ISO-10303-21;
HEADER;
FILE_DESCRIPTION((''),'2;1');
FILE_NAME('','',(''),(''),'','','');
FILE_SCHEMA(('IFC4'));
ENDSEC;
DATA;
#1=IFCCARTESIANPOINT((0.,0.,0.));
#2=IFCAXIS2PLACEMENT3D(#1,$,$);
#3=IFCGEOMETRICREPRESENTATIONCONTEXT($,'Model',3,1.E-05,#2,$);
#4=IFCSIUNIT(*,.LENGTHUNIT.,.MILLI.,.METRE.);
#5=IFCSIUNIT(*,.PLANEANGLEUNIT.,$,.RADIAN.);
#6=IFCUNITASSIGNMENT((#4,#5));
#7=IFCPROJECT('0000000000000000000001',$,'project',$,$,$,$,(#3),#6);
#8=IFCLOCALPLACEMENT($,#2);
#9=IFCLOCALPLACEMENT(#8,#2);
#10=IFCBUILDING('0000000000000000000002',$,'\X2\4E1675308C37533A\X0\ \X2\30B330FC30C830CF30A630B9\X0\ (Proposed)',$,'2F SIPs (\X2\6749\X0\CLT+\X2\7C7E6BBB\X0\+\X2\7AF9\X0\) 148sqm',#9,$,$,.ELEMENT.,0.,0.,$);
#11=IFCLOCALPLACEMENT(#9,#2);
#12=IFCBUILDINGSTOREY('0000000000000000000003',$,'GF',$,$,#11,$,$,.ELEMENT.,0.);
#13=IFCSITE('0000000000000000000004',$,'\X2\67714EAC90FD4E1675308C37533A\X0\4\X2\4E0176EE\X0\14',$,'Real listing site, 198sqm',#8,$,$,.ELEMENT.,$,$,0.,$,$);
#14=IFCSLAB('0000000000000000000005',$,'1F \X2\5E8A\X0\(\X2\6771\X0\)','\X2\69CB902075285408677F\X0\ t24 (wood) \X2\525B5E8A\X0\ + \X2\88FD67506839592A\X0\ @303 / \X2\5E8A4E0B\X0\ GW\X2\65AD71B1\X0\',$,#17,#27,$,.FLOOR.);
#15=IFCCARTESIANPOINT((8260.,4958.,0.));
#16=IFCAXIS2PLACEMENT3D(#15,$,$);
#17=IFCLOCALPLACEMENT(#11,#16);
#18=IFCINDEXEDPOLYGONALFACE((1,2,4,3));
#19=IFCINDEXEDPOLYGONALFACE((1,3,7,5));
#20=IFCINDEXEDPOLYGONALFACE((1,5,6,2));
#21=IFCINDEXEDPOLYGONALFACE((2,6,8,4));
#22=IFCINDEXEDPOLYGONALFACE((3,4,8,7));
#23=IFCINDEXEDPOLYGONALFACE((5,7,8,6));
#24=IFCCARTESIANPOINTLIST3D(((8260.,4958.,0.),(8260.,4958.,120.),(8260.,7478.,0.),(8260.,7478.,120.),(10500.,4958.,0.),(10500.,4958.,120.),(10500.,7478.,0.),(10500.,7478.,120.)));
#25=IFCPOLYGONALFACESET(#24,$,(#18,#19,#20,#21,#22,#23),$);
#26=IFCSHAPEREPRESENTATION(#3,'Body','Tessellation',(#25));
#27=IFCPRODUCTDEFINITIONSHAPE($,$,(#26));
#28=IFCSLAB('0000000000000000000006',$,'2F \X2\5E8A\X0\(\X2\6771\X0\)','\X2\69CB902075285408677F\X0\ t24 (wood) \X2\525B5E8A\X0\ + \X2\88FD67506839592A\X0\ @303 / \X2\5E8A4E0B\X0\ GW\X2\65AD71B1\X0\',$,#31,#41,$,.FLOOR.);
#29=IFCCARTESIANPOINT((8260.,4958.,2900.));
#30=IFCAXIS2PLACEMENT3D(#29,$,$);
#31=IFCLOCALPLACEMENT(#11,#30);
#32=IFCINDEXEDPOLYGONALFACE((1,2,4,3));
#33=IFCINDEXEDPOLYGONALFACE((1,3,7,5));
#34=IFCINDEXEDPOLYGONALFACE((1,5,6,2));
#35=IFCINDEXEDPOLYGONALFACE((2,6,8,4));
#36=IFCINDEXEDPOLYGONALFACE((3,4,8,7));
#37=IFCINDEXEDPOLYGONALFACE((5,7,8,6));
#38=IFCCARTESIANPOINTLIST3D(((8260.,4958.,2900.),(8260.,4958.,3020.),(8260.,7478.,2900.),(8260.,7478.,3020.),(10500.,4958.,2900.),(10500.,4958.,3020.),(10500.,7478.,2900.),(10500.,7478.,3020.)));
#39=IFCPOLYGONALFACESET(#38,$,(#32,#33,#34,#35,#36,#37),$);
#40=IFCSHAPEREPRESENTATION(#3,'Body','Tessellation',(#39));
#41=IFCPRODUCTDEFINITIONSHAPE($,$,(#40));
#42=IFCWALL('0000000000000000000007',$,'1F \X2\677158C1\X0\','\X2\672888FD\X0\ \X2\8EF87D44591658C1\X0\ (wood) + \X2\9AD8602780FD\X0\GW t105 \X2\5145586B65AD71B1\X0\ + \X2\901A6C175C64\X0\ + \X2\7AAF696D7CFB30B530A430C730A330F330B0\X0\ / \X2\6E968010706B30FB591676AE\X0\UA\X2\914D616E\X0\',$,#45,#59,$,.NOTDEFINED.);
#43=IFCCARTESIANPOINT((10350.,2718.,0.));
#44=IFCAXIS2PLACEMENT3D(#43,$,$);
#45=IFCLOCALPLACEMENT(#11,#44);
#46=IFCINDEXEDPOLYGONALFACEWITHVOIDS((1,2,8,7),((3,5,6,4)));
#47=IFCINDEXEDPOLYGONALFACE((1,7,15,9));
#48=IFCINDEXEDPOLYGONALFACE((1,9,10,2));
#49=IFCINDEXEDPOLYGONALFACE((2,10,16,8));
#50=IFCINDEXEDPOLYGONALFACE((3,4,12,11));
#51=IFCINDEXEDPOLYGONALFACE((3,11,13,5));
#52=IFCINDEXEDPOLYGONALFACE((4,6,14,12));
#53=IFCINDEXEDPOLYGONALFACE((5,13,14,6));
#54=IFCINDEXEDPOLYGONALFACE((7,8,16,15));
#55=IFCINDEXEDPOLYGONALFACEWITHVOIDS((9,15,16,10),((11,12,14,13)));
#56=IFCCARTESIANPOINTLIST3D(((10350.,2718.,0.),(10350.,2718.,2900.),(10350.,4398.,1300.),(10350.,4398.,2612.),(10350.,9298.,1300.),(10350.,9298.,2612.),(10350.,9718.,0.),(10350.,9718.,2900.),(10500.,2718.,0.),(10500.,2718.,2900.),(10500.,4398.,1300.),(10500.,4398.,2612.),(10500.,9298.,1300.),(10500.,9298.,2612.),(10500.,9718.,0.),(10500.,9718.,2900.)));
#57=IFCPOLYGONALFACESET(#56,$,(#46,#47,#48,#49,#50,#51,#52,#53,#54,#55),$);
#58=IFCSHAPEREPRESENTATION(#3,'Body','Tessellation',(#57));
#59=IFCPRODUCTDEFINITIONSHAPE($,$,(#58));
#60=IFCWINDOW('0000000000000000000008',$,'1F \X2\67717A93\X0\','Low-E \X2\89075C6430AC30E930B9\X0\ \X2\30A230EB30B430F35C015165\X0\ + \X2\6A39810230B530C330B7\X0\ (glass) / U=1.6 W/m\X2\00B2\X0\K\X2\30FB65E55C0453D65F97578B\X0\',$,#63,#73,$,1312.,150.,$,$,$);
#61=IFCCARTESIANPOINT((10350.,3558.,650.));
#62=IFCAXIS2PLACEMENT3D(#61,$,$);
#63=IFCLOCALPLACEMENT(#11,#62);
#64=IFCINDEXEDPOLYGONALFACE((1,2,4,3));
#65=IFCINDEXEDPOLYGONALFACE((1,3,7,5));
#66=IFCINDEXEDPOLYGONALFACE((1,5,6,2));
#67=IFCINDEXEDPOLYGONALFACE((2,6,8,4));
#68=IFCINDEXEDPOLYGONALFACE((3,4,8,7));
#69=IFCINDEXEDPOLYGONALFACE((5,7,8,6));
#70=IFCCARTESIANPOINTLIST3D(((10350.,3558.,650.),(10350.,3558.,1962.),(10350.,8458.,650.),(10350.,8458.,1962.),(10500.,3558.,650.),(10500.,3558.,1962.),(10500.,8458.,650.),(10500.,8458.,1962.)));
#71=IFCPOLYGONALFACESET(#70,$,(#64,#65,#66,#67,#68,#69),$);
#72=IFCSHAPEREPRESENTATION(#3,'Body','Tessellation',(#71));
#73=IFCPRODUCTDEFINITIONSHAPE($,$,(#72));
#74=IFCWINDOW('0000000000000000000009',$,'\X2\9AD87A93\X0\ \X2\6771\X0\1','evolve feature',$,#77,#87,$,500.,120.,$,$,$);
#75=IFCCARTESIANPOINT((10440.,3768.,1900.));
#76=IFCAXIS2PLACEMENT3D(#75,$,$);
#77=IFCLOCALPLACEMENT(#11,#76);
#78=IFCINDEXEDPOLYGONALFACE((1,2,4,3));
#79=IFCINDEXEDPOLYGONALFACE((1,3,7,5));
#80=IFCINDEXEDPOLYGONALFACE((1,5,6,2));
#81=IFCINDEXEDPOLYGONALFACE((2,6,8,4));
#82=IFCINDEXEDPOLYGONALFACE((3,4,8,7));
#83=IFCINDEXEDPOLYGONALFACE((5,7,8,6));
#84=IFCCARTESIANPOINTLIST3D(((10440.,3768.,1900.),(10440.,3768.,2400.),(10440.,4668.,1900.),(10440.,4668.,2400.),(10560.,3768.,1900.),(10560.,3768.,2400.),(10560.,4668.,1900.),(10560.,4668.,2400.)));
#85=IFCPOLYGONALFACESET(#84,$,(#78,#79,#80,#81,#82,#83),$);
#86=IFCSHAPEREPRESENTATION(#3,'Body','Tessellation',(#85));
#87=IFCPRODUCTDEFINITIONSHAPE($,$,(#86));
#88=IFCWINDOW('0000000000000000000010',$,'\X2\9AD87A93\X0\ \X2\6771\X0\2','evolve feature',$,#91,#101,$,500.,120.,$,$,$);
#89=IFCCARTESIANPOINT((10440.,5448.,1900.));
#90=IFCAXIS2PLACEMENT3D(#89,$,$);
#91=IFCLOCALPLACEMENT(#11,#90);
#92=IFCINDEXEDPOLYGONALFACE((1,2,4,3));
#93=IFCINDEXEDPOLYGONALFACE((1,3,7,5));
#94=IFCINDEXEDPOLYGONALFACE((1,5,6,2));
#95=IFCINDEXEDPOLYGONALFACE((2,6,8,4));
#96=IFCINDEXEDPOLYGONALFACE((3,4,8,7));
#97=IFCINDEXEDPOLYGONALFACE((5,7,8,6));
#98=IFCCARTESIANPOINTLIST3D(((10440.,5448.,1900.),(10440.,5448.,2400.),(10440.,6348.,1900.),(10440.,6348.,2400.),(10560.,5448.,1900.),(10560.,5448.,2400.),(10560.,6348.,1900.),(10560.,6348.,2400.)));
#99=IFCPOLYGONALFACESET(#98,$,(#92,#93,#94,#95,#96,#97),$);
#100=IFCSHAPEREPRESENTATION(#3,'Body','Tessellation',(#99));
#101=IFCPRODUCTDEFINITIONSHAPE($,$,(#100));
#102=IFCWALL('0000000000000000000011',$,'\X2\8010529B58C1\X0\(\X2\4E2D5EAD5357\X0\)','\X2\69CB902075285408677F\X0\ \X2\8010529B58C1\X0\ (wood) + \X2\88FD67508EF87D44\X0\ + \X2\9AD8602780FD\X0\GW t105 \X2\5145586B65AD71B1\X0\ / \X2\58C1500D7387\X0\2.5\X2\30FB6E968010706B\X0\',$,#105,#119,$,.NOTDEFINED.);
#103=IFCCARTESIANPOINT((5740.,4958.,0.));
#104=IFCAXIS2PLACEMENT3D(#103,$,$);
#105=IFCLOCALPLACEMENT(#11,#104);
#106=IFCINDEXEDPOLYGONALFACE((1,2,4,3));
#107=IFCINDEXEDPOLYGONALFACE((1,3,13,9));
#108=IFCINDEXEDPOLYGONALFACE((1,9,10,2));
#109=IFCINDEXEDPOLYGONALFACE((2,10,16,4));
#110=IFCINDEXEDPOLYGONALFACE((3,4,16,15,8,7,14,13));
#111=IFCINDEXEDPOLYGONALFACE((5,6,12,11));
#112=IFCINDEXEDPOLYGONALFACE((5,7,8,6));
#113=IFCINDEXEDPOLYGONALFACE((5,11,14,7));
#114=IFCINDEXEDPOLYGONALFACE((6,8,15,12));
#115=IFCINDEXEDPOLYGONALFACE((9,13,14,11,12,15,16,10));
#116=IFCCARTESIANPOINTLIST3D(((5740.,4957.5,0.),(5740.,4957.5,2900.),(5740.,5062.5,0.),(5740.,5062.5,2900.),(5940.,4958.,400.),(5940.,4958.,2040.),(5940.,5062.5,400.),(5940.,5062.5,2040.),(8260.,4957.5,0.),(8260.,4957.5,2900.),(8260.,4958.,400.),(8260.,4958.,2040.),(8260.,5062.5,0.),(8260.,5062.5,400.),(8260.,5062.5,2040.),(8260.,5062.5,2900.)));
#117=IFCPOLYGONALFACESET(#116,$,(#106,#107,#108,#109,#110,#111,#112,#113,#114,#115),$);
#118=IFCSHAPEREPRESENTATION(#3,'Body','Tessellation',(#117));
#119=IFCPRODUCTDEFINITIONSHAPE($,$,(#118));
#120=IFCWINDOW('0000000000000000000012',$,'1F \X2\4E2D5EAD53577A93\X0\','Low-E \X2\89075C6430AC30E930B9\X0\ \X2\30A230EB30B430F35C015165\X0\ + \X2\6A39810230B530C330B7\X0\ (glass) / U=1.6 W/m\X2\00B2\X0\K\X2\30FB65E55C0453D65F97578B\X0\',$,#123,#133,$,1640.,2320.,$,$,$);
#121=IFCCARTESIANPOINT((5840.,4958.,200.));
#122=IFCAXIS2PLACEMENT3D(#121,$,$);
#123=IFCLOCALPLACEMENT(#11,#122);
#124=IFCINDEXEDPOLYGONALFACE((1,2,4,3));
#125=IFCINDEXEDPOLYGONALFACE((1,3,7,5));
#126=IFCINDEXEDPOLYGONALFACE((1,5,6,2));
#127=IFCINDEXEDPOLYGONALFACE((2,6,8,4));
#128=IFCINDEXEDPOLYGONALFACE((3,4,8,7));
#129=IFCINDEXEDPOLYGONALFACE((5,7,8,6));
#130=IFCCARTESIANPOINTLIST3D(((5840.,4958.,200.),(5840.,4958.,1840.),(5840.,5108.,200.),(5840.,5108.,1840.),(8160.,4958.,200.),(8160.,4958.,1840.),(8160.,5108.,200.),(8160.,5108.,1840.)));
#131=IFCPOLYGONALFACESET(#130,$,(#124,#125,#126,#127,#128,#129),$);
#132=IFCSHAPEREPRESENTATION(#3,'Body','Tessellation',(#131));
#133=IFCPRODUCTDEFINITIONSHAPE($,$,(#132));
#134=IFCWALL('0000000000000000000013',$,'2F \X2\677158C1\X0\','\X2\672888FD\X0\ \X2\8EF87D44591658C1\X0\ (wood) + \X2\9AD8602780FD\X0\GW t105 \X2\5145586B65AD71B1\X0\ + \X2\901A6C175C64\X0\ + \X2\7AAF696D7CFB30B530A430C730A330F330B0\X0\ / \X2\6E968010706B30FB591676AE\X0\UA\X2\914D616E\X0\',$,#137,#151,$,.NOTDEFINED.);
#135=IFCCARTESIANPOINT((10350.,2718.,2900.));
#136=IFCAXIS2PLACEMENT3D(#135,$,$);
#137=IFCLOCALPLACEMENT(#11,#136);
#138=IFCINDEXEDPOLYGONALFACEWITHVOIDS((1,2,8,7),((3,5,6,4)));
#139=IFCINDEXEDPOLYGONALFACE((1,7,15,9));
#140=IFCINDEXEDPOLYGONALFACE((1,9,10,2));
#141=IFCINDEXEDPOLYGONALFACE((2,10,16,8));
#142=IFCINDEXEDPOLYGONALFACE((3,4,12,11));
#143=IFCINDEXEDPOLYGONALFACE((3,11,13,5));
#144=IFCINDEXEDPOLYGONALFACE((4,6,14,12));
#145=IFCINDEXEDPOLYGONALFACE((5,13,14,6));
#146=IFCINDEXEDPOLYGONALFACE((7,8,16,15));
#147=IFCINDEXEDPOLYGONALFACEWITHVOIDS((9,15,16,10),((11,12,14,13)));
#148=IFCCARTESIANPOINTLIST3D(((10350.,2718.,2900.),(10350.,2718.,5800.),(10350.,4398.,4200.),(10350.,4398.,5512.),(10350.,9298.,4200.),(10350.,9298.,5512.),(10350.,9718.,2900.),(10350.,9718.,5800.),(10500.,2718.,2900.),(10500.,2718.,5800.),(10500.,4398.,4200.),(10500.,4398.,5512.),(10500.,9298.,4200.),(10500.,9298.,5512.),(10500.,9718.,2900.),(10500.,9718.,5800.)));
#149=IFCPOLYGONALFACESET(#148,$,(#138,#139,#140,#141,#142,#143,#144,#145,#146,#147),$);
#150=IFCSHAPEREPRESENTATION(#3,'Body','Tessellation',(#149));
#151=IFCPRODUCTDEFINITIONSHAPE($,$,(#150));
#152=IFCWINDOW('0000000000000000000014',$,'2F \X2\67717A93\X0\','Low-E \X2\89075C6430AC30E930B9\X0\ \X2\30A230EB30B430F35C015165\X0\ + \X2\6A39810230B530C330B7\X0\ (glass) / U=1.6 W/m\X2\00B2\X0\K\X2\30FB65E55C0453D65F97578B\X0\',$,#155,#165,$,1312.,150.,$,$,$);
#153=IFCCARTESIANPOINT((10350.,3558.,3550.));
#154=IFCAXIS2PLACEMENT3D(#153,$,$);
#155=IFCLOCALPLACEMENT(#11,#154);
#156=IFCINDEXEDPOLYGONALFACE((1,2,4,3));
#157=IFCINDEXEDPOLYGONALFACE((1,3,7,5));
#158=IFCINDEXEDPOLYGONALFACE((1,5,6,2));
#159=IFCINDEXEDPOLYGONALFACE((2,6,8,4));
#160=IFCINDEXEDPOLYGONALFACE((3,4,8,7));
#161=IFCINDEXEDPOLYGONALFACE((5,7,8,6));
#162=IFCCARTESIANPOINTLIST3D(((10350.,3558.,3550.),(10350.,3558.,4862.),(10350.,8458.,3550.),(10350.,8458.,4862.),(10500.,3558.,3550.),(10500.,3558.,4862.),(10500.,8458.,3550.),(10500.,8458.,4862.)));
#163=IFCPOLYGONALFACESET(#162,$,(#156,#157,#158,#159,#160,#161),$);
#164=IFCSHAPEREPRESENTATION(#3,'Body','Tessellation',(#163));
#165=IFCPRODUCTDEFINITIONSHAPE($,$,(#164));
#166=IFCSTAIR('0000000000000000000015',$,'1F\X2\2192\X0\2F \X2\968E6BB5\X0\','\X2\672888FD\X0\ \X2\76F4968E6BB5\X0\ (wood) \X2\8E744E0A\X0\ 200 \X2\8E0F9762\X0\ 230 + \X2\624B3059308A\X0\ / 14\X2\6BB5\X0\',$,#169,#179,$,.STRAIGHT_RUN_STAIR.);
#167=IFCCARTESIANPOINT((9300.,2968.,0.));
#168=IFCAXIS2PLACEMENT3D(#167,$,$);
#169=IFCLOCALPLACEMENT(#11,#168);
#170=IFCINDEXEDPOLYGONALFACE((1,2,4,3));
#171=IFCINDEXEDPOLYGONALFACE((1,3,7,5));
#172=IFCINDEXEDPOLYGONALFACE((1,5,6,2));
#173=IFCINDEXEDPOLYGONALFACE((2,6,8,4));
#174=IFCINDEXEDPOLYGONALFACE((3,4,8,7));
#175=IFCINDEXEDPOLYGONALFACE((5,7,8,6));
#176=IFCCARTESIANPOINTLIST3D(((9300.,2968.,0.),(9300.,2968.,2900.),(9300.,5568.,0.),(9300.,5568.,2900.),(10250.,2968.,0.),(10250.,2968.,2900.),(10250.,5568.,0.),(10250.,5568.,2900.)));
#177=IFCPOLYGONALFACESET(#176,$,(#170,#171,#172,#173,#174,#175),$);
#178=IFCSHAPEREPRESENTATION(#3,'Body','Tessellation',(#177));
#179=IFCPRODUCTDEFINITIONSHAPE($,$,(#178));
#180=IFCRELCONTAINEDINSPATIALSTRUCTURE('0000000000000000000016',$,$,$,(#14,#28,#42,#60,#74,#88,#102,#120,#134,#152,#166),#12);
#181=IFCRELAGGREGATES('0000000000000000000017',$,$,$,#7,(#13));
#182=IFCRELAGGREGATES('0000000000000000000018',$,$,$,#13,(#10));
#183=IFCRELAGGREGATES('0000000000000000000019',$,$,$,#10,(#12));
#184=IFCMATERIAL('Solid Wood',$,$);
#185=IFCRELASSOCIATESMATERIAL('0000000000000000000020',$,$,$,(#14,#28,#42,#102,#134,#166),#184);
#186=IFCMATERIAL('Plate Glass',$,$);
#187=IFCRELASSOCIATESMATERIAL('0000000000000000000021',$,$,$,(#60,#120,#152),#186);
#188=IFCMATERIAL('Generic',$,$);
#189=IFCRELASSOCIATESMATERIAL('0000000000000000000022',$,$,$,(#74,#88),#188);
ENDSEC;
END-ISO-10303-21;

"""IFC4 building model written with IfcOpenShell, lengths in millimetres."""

from ifc_helpers import new_model, si_unit, frame, frame_2d, origin, place, context, project, spatial, rectangle, extrude, material, element, fill, save


model = new_model("IFC4")

# Units and contexts
model_context = context("Model", 3, precision=1e-05, world=origin())
ifc_project = project(units=[si_unit("LENGTHUNIT", "METRE", prefix="MILLI"), si_unit("PLANEANGLEUNIT", "RADIAN")], contexts=[model_context])

# Site, building, storey
site_placement = place(None, origin())
site = spatial("IfcSite", under=ifc_project, at=site_placement, Name="東京都世田谷区4丁目14", ObjectType="Real listing site, 198sqm", CompositionType="ELEMENT", RefElevation=0.0)
building_placement = place(site_placement, origin())
building = spatial("IfcBuilding", under=site, at=building_placement, Name="世田谷区 コートハウス (Proposed)", ObjectType="2F SIPs (杉CLT+籾殻+竹) 148sqm", CompositionType="ELEMENT", ElevationOfRefHeight=0.0, ElevationOfTerrain=0.0)
storey_placement = place(building_placement, origin())
storey = spatial("IfcBuildingStorey", under=building, at=storey_placement, Name="GF", CompositionType="ELEMENT", Elevation=0.0)

# Slabs
ifc_material_1 = material(Name="Solid Wood")
slab_1_placement = place(storey_placement, frame((8260.0, 4958.0, 0.0)))
element("IfcSlab", 1, at=slab_1_placement, inside=storey, material=ifc_material_1, Name="1F 床(東)", Description="構造用合板 t24 (wood) 剛床 + 製材根太 @303 / 床下 GW断熱", PredefinedType="FLOOR", context=model_context, shape_type="SweptSolid", body=[
    extrude(rectangle(XDim=2240.0, YDim=2520.0, at=frame_2d((1120.0, 1260.0))), frame((8260.0, 4958.0, 0.0)), (0.0, 0.0, 1.0), 120.0),
])
slab_2_placement = place(storey_placement, frame((8260.0, 4958.0, 2900.0)))
element("IfcSlab", 2, at=slab_2_placement, inside=storey, material=ifc_material_1, Name="2F 床(東)", Description="構造用合板 t24 (wood) 剛床 + 製材根太 @303 / 床下 GW断熱", PredefinedType="FLOOR", context=model_context, shape_type="SweptSolid", body=[
    extrude(rectangle(XDim=2240.0, YDim=2520.0, at=frame_2d((1120.0, 1260.0))), frame((8260.0, 4958.0, 2900.0)), (0.0, 0.0, 1.0), 120.0),
])

# Wall, openings, windows
wall_1_placement = place(storey_placement, frame((10350.0, 2718.0, 0.0)))
wall_1 = element("IfcWall", 3, at=wall_1_placement, inside=storey, material=ifc_material_1, Name="1F 東壁", Description="木製 軸組外壁 (wood) + 高性能GW t105 充填断熱 + 通気層 + 窯業系サイディング / 準耐火・外皮UA配慮", PredefinedType="NOTDEFINED", context=model_context, shape_type="SweptSolid", body=[
    extrude(rectangle(XDim=150.0, YDim=7000.0, at=frame_2d((75.0, 3500.0))), frame((10350.0, 2718.0, 0.0)), (0.0, 0.0, 1.0), 2900.0),
])
opening_1_placement = place(storey_placement, frame((10350.0, 3558.0, 650.0)))
opening_1 = element("IfcOpeningElement", 4, at=opening_1_placement, cuts=wall_1, PredefinedType="NOTDEFINED", context=model_context, shape_type="SweptSolid", body=[
    extrude(rectangle(XDim=150.0, YDim=4900.0, at=frame_2d((75.0, 2450.0))), frame((10350.0, 3558.0, 650.0)), (0.0, 0.0, 1.0), 1312.0),
])
opening_2_placement = place(storey_placement, frame((10440.0, 3768.0, 1900.0)))
opening_2 = element("IfcOpeningElement", 5, at=opening_2_placement, cuts=wall_1, PredefinedType="NOTDEFINED", context=model_context, shape_type="SweptSolid", body=[
    extrude(rectangle(XDim=120.0, YDim=900.0, at=frame_2d((60.0, 450.0))), frame((10440.0, 3768.0, 1900.0)), (0.0, 0.0, 1.0), 500.0),
])
opening_3_placement = place(storey_placement, frame((10440.0, 5448.0, 1900.0)))
opening_3 = element("IfcOpeningElement", 6, at=opening_3_placement, cuts=wall_1, PredefinedType="NOTDEFINED", context=model_context, shape_type="SweptSolid", body=[
    extrude(rectangle(XDim=120.0, YDim=900.0, at=frame_2d((60.0, 450.0))), frame((10440.0, 5448.0, 1900.0)), (0.0, 0.0, 1.0), 500.0),
])
ifc_material_2 = material(Name="Plate Glass")
window_1_placement = place(storey_placement, frame((10350.0, 3558.0, 650.0)))
window_1 = element("IfcWindow", 7, at=window_1_placement, inside=storey, material=ifc_material_2, Name="1F 東窓", Description="Low-E 複層ガラス アルゴン封入 + 樹脂サッシ (glass) / U=1.6 W/m²K・日射取得型", OverallHeight=1312.0, OverallWidth=150.0, context=model_context, shape_type="SweptSolid", body=[
    extrude(rectangle(XDim=150.0, YDim=4900.0, at=frame_2d((75.0, 2450.0))), frame((10350.0, 3558.0, 650.0)), (0.0, 0.0, 1.0), 1312.0),
])
fill(opening_1, window_1)
ifc_material_3 = material(Name="Generic")
window_2_placement = place(storey_placement, frame((10440.0, 3768.0, 1900.0)))
window_2 = element("IfcWindow", 8, at=window_2_placement, inside=storey, material=ifc_material_3, Name="高窓 東1", Description="evolve feature", OverallHeight=500.0, OverallWidth=120.0, context=model_context, shape_type="SweptSolid", body=[
    extrude(rectangle(XDim=120.0, YDim=900.0, at=frame_2d((60.0, 450.0))), frame((10440.0, 3768.0, 1900.0)), (0.0, 0.0, 1.0), 500.0),
])
fill(opening_2, window_2)
window_3_placement = place(storey_placement, frame((10440.0, 5448.0, 1900.0)))
window_3 = element("IfcWindow", 9, at=window_3_placement, inside=storey, material=ifc_material_3, Name="高窓 東2", Description="evolve feature", OverallHeight=500.0, OverallWidth=120.0, context=model_context, shape_type="SweptSolid", body=[
    extrude(rectangle(XDim=120.0, YDim=900.0, at=frame_2d((60.0, 450.0))), frame((10440.0, 5448.0, 1900.0)), (0.0, 0.0, 1.0), 500.0),
])
fill(opening_3, window_3)

# Wall, opening, window
wall_2_placement = place(storey_placement, frame((5740.0, 4958.0, 0.0)))
wall_2 = element("IfcWall", 10, at=wall_2_placement, inside=storey, material=ifc_material_1, Name="耐力壁(中庭南)", Description="構造用合板 耐力壁 (wood) + 製材軸組 + 高性能GW t105 充填断熱 / 壁倍率2.5・準耐火", PredefinedType="NOTDEFINED", context=model_context, shape_type="SweptSolid", body=[
    extrude(rectangle(XDim=2520.0, YDim=105.0, at=frame_2d((1260.0, 52.0))), frame((5740.0, 4958.0, 0.0)), (0.0, 0.0, 1.0), 2900.0),
])
opening_4_placement = place(storey_placement, frame((5840.0, 4958.0, 200.0)))
opening_4 = element("IfcOpeningElement", 11, at=opening_4_placement, cuts=wall_2, PredefinedType="NOTDEFINED", context=model_context, shape_type="SweptSolid", body=[
    extrude(rectangle(XDim=2320.0, YDim=150.0, at=frame_2d((1160.0, 75.0))), frame((5840.0, 4958.0, 200.0)), (0.0, 0.0, 1.0), 1640.0),
])
window_4_placement = place(storey_placement, frame((5840.0, 4958.0, 200.0)))
window_4 = element("IfcWindow", 12, at=window_4_placement, inside=storey, material=ifc_material_2, Name="1F 中庭南窓", Description="Low-E 複層ガラス アルゴン封入 + 樹脂サッシ (glass) / U=1.6 W/m²K・日射取得型", OverallHeight=1640.0, OverallWidth=2320.0, context=model_context, shape_type="SweptSolid", body=[
    extrude(rectangle(XDim=2320.0, YDim=150.0, at=frame_2d((1160.0, 75.0))), frame((5840.0, 4958.0, 200.0)), (0.0, 0.0, 1.0), 1640.0),
])
fill(opening_4, window_4)

# Wall, opening, window
wall_3_placement = place(storey_placement, frame((10350.0, 2718.0, 2900.0)))
wall_3 = element("IfcWall", 13, at=wall_3_placement, inside=storey, material=ifc_material_1, Name="2F 東壁", Description="木製 軸組外壁 (wood) + 高性能GW t105 充填断熱 + 通気層 + 窯業系サイディング / 準耐火・外皮UA配慮", PredefinedType="NOTDEFINED", context=model_context, shape_type="SweptSolid", body=[
    extrude(rectangle(XDim=150.0, YDim=7000.0, at=frame_2d((75.0, 3500.0))), frame((10350.0, 2718.0, 2900.0)), (0.0, 0.0, 1.0), 2900.0),
])
opening_5_placement = place(storey_placement, frame((10350.0, 3558.0, 3550.0)))
opening_5 = element("IfcOpeningElement", 14, at=opening_5_placement, cuts=wall_3, PredefinedType="NOTDEFINED", context=model_context, shape_type="SweptSolid", body=[
    extrude(rectangle(XDim=150.0, YDim=4900.0, at=frame_2d((75.0, 2450.0))), frame((10350.0, 3558.0, 3550.0)), (0.0, 0.0, 1.0), 1312.0),
])
window_5_placement = place(storey_placement, frame((10350.0, 3558.0, 3550.0)))
window_5 = element("IfcWindow", 15, at=window_5_placement, inside=storey, material=ifc_material_2, Name="2F 東窓", Description="Low-E 複層ガラス アルゴン封入 + 樹脂サッシ (glass) / U=1.6 W/m²K・日射取得型", OverallHeight=1312.0, OverallWidth=150.0, context=model_context, shape_type="SweptSolid", body=[
    extrude(rectangle(XDim=150.0, YDim=4900.0, at=frame_2d((75.0, 2450.0))), frame((10350.0, 3558.0, 3550.0)), (0.0, 0.0, 1.0), 1312.0),
])
fill(opening_5, window_5)

# Stair
stair_placement = place(storey_placement, frame((9300.0, 2968.0, 0.0)))
element("IfcStair", 16, at=stair_placement, inside=storey, material=ifc_material_1, Name="1F→2F 階段", Description="木製 直階段 (wood) 蹴上 200 踏面 230 + 手すり / 14段", PredefinedType="STRAIGHT_RUN_STAIR", context=model_context, shape_type="SweptSolid", body=[
    extrude(rectangle(XDim=950.0, YDim=2600.0, at=frame_2d((475.0, 1300.0))), frame((9300.0, 2968.0, 0.0)), (0.0, 0.0, 1.0), 2900.0),
])

save(model, "model.ifc")
